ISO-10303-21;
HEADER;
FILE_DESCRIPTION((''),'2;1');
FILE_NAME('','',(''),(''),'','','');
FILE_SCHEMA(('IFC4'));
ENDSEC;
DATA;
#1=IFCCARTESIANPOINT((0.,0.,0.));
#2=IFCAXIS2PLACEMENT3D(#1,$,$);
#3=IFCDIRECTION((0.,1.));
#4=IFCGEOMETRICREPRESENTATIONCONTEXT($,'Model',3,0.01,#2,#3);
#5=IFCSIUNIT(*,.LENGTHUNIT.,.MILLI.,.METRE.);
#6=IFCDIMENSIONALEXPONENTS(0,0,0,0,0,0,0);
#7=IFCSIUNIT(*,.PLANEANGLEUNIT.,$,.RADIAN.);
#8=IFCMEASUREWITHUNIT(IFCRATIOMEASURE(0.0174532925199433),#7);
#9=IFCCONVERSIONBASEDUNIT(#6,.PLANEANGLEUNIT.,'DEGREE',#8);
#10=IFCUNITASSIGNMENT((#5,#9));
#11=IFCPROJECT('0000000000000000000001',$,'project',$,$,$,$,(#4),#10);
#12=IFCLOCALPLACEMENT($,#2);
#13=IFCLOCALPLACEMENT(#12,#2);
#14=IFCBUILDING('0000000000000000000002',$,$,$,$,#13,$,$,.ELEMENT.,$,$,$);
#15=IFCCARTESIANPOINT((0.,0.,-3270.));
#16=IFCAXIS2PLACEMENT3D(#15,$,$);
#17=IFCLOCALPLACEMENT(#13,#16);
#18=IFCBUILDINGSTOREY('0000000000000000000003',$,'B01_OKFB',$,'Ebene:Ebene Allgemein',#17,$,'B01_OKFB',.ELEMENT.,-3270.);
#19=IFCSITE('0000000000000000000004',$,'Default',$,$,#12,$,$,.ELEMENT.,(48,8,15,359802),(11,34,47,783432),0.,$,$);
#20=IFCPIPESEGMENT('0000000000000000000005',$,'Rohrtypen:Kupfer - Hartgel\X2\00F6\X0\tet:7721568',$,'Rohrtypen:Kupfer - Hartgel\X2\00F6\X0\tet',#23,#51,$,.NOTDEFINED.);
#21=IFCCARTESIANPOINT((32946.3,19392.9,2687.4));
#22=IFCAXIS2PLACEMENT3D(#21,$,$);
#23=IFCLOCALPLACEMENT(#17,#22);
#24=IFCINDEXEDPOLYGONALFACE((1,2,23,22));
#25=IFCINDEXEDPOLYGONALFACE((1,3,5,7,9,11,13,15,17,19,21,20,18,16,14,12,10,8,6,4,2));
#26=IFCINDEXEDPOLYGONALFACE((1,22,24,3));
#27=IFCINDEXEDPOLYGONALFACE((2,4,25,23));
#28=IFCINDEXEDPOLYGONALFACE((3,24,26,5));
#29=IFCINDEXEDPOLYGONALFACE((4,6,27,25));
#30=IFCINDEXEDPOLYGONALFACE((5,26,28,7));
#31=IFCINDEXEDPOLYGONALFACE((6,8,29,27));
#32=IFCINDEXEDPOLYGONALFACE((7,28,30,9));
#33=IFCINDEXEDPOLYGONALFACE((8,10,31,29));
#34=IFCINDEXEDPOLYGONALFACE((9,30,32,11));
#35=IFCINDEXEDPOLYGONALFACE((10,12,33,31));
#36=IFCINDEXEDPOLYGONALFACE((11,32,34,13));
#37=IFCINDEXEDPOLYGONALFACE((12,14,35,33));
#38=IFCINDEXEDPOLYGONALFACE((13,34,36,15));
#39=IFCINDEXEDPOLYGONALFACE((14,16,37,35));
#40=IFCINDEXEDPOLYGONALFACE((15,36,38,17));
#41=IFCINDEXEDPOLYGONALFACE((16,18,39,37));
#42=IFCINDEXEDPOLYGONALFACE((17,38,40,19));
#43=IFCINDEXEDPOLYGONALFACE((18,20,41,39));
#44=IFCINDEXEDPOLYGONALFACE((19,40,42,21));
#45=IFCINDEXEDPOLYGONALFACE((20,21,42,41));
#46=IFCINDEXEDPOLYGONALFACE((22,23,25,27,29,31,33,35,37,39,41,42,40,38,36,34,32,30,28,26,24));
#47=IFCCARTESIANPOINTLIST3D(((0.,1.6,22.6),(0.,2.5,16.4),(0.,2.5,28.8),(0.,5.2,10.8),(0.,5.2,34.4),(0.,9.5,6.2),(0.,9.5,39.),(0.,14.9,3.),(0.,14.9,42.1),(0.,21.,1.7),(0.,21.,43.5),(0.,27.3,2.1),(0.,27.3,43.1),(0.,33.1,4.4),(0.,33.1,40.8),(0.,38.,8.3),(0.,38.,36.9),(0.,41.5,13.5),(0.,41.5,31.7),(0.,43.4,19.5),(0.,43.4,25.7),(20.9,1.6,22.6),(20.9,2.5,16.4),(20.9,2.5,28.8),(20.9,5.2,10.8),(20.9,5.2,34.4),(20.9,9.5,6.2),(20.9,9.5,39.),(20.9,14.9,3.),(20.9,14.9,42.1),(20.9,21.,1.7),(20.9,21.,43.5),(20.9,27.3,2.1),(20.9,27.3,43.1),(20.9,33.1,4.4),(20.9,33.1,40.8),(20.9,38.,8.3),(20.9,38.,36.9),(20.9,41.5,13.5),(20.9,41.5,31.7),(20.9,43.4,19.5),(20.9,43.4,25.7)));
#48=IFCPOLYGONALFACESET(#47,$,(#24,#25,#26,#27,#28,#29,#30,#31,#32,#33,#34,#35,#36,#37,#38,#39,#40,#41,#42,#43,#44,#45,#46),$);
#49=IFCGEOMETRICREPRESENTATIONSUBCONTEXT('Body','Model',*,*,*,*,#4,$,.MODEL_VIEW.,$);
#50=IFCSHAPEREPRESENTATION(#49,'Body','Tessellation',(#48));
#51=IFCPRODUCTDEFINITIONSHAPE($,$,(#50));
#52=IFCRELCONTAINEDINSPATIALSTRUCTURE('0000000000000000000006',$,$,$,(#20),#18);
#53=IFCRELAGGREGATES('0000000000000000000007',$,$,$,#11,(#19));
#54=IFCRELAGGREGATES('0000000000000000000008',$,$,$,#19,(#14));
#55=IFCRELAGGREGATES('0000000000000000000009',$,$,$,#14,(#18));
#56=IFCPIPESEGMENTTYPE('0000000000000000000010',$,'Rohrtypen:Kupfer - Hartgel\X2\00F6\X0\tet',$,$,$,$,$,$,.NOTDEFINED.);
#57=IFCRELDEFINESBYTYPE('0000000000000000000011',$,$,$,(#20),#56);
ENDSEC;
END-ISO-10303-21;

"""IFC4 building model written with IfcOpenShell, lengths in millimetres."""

from ifc_helpers import new_model, entity, si_unit, converted_unit, direction, frame, origin, origin_2d_with_axis, place, context, subcontext, project, spatial, circle, extrude, type_object, element, save


model = new_model("IFC4")

# Units and contexts
model_context = context("Model", 3, precision=0.01, world=origin(), true_north=direction((0.0, 1.0)))
body_context = subcontext(model_context, "Body", "Model", "MODEL_VIEW")
ifc_project = project(units=[si_unit("LENGTHUNIT", "METRE", prefix="MILLI"), converted_unit("PLANEANGLEUNIT", "DEGREE", entity("IfcRatioMeasure", 0.0174532925199433), si_unit("PLANEANGLEUNIT", "RADIAN"), dimensions=[0, 0, 0, 0, 0, 0, 0])], contexts=[model_context])

# Site, building, storey
site_placement = place(None, origin())
site = spatial("IfcSite", under=ifc_project, at=site_placement, Name="Default", CompositionType="ELEMENT", RefLatitude=(48, 8, 15, 359802), RefLongitude=(11, 34, 47, 783432), RefElevation=0.0)
building_placement = place(site_placement, origin())
building = spatial("IfcBuilding", under=site, at=building_placement, CompositionType="ELEMENT")
storey_placement = place(building_placement, frame((0.0, 0.0, -3270.0)))
storey = spatial("IfcBuildingStorey", under=building, at=storey_placement, Name="B01_OKFB", ObjectType="Ebene:Ebene Allgemein", LongName="B01_OKFB", CompositionType="ELEMENT", Elevation=-3270.0)

# Pipe segment
pipe_segment_type = type_object("IfcPipeSegmentType", Name="Rohrtypen:Kupfer - Hartgelötet", PredefinedType="NOTDEFINED")
pipe_segment_1_placement = place(storey_placement, frame((32946.3, 19392.9, 2687.4)))
element("IfcPipeSegment", 1, at=pipe_segment_1_placement, inside=storey, type_object=pipe_segment_type, Name="Rohrtypen:Kupfer - Hartgelötet:7721568", ObjectType="Rohrtypen:Kupfer - Hartgelötet", PredefinedType="NOTDEFINED", context=body_context, shape_type="SweptSolid", body=[
    extrude(circle(Radius=21.0, at=origin_2d_with_axis()), frame((0.0, 22.6, 22.6), z_axis=(1.0, 0.0, 0.0), x_axis=(0.0, -1.0, 0.0)), (0.0, 0.0, 1.0), 20.9),
])

save(model, "model.ifc")
